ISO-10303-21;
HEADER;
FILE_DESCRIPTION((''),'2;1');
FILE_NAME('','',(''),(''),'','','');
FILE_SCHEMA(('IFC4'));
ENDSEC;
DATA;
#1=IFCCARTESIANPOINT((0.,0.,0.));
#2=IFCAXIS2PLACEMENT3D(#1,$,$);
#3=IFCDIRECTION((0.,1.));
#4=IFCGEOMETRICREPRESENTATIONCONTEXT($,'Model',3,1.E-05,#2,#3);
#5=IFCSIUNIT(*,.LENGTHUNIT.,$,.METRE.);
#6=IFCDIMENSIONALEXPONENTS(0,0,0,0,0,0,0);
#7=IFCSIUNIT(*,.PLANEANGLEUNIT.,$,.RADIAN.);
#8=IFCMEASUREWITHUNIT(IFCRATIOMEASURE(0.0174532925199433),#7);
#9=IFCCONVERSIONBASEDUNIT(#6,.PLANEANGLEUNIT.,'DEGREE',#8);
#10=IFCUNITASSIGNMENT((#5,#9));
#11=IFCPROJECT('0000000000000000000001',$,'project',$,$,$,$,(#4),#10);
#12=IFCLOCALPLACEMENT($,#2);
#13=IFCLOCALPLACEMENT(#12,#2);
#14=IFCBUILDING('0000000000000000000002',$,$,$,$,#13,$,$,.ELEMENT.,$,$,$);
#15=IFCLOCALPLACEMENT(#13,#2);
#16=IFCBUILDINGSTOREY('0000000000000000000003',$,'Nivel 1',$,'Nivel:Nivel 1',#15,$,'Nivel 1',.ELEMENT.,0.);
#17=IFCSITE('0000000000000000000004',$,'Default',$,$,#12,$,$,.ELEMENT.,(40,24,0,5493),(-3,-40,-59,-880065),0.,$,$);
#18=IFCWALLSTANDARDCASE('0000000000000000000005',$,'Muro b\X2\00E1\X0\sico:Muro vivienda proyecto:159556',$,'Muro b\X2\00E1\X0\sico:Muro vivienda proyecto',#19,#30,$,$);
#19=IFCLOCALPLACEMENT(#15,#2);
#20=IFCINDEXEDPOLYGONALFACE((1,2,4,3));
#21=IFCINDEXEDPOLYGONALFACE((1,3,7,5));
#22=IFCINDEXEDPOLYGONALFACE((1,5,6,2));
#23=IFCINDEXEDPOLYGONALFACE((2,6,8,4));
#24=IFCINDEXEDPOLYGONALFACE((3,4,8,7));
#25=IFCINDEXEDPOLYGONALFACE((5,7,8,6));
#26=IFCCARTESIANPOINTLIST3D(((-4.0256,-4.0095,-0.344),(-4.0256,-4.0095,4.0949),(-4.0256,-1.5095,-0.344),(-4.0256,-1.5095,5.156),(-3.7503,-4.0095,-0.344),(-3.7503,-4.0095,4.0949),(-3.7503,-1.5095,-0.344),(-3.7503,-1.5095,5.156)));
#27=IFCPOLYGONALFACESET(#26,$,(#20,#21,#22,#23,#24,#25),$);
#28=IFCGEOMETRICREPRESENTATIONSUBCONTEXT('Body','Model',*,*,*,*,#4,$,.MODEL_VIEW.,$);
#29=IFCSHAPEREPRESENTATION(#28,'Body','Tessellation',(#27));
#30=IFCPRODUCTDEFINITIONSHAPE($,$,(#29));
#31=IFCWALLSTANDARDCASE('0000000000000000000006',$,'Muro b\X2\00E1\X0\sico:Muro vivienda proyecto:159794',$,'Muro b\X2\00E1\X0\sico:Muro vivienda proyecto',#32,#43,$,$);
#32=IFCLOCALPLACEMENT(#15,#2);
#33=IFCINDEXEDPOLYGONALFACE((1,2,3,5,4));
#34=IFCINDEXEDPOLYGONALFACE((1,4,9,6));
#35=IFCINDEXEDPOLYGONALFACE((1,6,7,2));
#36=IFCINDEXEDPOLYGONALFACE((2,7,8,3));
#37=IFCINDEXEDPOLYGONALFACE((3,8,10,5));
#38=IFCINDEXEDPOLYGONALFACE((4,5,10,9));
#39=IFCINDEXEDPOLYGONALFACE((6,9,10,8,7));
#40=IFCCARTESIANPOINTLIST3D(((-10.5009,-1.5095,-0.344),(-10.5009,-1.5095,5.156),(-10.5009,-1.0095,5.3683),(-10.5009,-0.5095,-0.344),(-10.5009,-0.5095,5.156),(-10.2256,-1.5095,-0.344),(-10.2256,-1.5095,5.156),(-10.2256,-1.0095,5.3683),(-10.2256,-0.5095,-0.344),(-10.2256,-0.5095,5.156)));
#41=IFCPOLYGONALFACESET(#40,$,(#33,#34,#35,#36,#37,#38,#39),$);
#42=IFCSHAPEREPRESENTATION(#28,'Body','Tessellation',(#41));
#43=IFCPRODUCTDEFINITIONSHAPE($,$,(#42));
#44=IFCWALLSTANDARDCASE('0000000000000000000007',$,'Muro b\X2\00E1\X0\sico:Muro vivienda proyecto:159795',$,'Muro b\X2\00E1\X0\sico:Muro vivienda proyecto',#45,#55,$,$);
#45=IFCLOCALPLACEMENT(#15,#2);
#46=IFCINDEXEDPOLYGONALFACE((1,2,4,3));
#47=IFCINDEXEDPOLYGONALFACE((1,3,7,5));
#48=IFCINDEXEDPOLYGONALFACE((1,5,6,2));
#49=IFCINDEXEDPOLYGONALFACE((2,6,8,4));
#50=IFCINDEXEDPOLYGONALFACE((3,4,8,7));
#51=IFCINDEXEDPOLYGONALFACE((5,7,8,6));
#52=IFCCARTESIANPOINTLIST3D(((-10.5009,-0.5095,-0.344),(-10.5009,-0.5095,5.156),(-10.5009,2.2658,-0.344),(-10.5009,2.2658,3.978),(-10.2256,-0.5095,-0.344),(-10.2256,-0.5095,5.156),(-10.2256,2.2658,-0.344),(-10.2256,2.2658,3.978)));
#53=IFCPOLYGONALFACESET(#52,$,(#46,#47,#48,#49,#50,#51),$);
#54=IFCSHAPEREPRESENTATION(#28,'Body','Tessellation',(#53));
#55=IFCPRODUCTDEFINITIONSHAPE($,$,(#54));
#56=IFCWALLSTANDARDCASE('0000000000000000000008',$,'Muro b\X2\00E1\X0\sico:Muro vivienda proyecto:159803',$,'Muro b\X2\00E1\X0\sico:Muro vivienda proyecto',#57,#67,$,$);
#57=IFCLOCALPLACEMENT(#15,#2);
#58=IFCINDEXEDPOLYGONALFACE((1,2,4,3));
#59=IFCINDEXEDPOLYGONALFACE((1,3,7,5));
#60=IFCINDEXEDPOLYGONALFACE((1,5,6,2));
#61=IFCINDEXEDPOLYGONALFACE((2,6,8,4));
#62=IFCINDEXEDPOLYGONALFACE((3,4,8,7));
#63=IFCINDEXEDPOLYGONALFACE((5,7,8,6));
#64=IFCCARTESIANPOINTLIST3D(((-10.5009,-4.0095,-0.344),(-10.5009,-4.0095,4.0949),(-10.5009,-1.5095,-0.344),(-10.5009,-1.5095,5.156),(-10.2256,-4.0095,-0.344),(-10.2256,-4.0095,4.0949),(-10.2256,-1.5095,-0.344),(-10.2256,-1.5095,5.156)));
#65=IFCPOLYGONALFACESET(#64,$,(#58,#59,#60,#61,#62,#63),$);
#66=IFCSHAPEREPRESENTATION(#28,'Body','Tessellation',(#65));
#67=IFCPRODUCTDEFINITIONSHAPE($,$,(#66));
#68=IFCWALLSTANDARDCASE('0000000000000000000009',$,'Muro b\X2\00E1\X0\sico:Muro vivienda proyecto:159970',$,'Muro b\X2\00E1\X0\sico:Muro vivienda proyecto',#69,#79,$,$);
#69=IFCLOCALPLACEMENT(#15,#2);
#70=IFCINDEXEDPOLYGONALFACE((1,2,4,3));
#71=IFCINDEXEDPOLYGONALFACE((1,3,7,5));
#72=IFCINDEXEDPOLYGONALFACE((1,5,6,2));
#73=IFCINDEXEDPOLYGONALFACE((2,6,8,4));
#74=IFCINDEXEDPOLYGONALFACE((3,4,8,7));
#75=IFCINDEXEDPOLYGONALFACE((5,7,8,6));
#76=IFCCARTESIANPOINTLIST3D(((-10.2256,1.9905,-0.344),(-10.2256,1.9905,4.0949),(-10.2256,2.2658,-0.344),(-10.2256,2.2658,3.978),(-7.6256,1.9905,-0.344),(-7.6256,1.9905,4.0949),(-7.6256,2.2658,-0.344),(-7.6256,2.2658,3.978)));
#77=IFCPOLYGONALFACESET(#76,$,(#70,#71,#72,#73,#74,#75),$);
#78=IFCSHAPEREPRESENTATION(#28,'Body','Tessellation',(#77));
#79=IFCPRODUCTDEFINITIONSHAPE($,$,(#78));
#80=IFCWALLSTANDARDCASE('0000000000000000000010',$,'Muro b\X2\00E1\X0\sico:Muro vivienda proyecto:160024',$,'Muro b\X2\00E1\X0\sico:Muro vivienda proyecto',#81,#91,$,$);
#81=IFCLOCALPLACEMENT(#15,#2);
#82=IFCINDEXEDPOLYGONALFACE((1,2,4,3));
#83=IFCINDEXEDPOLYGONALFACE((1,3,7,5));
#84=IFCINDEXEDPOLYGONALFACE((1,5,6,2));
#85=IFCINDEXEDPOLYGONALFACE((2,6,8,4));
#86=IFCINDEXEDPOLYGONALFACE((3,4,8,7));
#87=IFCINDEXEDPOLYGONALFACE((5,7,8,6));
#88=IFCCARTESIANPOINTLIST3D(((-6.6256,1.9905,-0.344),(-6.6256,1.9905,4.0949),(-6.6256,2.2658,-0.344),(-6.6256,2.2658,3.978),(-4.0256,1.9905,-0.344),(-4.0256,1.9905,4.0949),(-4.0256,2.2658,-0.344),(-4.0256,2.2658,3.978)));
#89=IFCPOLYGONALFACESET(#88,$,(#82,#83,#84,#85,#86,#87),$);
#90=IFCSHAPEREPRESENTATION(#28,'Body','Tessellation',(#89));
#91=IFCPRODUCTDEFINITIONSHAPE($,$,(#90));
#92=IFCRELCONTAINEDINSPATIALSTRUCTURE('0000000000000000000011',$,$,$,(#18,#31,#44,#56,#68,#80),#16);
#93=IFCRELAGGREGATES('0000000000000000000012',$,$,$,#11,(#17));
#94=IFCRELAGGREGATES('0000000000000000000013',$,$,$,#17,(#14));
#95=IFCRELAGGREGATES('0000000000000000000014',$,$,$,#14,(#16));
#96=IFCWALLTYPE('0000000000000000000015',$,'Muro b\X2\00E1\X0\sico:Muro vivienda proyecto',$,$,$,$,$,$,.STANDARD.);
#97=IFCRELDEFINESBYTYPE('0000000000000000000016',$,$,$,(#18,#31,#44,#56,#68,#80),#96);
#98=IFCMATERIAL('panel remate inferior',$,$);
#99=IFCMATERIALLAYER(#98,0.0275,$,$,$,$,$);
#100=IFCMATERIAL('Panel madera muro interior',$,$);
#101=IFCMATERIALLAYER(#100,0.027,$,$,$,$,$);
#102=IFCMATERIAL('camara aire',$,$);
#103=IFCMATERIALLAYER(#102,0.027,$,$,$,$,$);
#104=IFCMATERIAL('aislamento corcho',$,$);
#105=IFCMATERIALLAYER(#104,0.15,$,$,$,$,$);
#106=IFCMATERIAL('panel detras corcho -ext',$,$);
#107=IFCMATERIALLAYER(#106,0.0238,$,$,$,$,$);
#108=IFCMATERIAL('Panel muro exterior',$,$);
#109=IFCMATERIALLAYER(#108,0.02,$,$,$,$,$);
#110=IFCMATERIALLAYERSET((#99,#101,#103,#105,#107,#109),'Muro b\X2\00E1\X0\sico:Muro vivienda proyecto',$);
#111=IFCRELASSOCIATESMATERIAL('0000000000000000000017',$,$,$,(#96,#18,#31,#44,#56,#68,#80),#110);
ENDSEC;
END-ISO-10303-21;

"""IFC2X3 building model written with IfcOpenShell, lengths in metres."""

from ifc_helpers import new_model, entity, si_unit, converted_unit, direction, frame, frame_2d, origin, place, context, subcontext, project, spatial, polyline, rectangle, extrude, clip, bounded_halfspace, material, layer, layer_set, layer_usage, type_object, element, save


model = new_model("IFC2X3")

# Units and contexts
model_context = context("Model", 3, precision=1e-05, world=origin(), true_north=direction((0.0, 1.0)))
body_context = subcontext(model_context, "Body", "Model", "MODEL_VIEW")
ifc_project = project(units=[si_unit("LENGTHUNIT", "METRE"), converted_unit("PLANEANGLEUNIT", "DEGREE", entity("IfcRatioMeasure", 0.0174532925199433), si_unit("PLANEANGLEUNIT", "RADIAN"), dimensions=[0, 0, 0, 0, 0, 0, 0])], contexts=[model_context])

# Site, building, storey
site_placement = place(None, origin())
site = spatial("IfcSite", under=ifc_project, at=site_placement, Name="Default", CompositionType="ELEMENT", RefLatitude=(40, 24, 0, 5493), RefLongitude=(-3, -40, -59, -880065), RefElevation=0.0)
building_placement = place(site_placement, origin())
building = spatial("IfcBuilding", under=site, at=building_placement, CompositionType="ELEMENT")
storey_placement = place(building_placement, origin())
storey = spatial("IfcBuildingStorey", under=building, at=storey_placement, Name="Nivel 1", ObjectType="Nivel:Nivel 1", LongName="Nivel 1", CompositionType="ELEMENT", Elevation=0.0)

# Shared definitions
ifc_material_1 = material(Name="aislamento corcho")
ifc_material_2 = material(Name="camara aire")
ifc_material_3 = material(Name="panel remate inferior")

# Walls
ifc_layer_1 = layer(ifc_material_3, 0.0275)
ifc_material_4 = material(Name="Panel madera muro interior")
ifc_layer_2 = layer(ifc_material_4, 0.027)
ifc_layer_3 = layer(ifc_material_2, 0.027)
ifc_layer_4 = layer(ifc_material_1, 0.15)
ifc_material_5 = material(Name="panel detras corcho -ext")
ifc_layer_5 = layer(ifc_material_5, 0.0238)
ifc_material_6 = material(Name="Panel muro exterior")
ifc_layer_6 = layer(ifc_material_6, 0.02)
ifc_layer_set_1 = layer_set([ifc_layer_1, ifc_layer_2, ifc_layer_3, ifc_layer_4, ifc_layer_5, ifc_layer_6], Name="Muro básico:Muro vivienda proyecto")
wall_type = type_object("IfcWallType", Name="Muro básico:Muro vivienda proyecto", PredefinedType="STANDARD", material=ifc_layer_set_1)
ifc_layer_usage_1 = layer_usage(ifc_layer_set_1, "AXIS2", "POSITIVE", -0.1376)
wall_1_placement = place(storey_placement, frame((-3.8879, -4.0095, -0.344), z_axis=(0.0, 0.0, 1.0), x_axis=(0.0, 1.0, 0.0)))
element("IfcWallStandardCase", 1, at=wall_1_placement, inside=storey, type_object=wall_type, material=ifc_layer_usage_1, Name="Muro básico:Muro vivienda proyecto:159556", ObjectType="Muro básico:Muro vivienda proyecto", context=body_context, shape_type="Clipping", body=[
    clip(extrude(rectangle(XDim=2.5, YDim=0.2753, at=frame_2d((1.25, 0.0), x_axis=(-1.0, 0.0))), origin(), (0.0, 0.0, 1.0), 5.5), bounded_halfspace(frame((0.0, -0.1376, 4.4389), z_axis=(-0.390731, 0.0, 0.920505), x_axis=(0.0, -1.0, 0.0)), False, frame((0.0, -0.1376, 4.4389)), polyline([(0.0, 0.0), (2.5, 0.0), (2.5, 0.2753), (0.0, 0.2753), (0.0, 0.0)]))),
])
ifc_layer_usage_2 = layer_usage(ifc_layer_set_1, "AXIS2", "POSITIVE", -0.1376)
wall_2_placement = place(storey_placement, frame((-10.3632, -0.5095, -0.344), z_axis=(0.0, 0.0, 1.0), x_axis=(0.0, -1.0, 0.0)))
element("IfcWallStandardCase", 2, at=wall_2_placement, inside=storey, type_object=wall_type, material=ifc_layer_usage_2, Name="Muro básico:Muro vivienda proyecto:159794", ObjectType="Muro básico:Muro vivienda proyecto", context=body_context, shape_type="Clipping", body=[
    clip(clip(extrude(rectangle(XDim=1.0, YDim=0.2753, at=frame_2d((0.5, 0.0), x_axis=(-1.0, 0.0))), origin(), (0.0, 0.0, 1.0), 5.7123), bounded_halfspace(frame((0.5, -0.1376, 5.7123), z_axis=(0.390731, 0.0, 0.920505), x_axis=(0.0, 1.0, 0.0)), False, frame((0.5, -0.1376, 5.7123)), polyline([(0.0, 0.0), (0.5, 0.0), (0.5, 0.2753), (0.0, 0.2753), (0.0, 0.0)]))), bounded_halfspace(frame((0.0, -0.1377, 5.5), z_axis=(-0.390731, 0.0, 0.920505), x_axis=(0.0, -1.0, 0.0)), False, frame((0.0, -0.1377, 5.5)), polyline([(0.0, 0.0), (0.5, 0.0), (0.5, 0.2753), (0.0, 0.2753), (0.0, 0.0)]))),
])
ifc_layer_usage_3 = layer_usage(ifc_layer_set_1, "AXIS2", "POSITIVE", -0.1376)
wall_3_placement = place(storey_placement, frame((-10.3632, 2.2658, -0.344), z_axis=(0.0, 0.0, 1.0), x_axis=(0.0, -1.0, 0.0)))
element("IfcWallStandardCase", 3, at=wall_3_placement, inside=storey, type_object=wall_type, material=ifc_layer_usage_3, Name="Muro básico:Muro vivienda proyecto:159795", ObjectType="Muro básico:Muro vivienda proyecto", context=body_context, shape_type="Clipping", body=[
    clip(extrude(rectangle(XDim=2.7753, YDim=0.2753, at=frame_2d((1.3877, 0.0), x_axis=(-1.0, 0.0))), origin(), (0.0, 0.0, 1.0), 5.5), bounded_halfspace(frame((0.0, -0.1377, 4.322), z_axis=(-0.390731, 0.0, 0.920505), x_axis=(0.0, -1.0, 0.0)), False, frame((0.0, -0.1377, 4.322)), polyline([(0.0, 0.0), (2.7753, 0.0), (2.7753, 0.2753), (0.2753, 0.2753), (0.0, 0.2753), (0.0, 0.0)]))),
])
ifc_layer_usage_4 = layer_usage(ifc_layer_set_1, "AXIS2", "NEGATIVE", 0.1376)
wall_4_placement = place(storey_placement, frame((-10.3632, -4.0095, -0.344), z_axis=(0.0, 0.0, 1.0), x_axis=(0.0, 1.0, 0.0)))
element("IfcWallStandardCase", 4, at=wall_4_placement, inside=storey, type_object=wall_type, material=ifc_layer_usage_4, Name="Muro básico:Muro vivienda proyecto:159803", ObjectType="Muro básico:Muro vivienda proyecto", context=body_context, shape_type="Clipping", body=[
    clip(extrude(rectangle(XDim=2.5, YDim=0.2753, at=frame_2d((1.25, 0.0), x_axis=(-1.0, 0.0))), origin(), (0.0, 0.0, 1.0), 5.5), bounded_halfspace(frame((0.0, -0.1377, 4.4389), z_axis=(-0.390731, 0.0, 0.920505), x_axis=(0.0, -1.0, 0.0)), False, frame((0.0, -0.1377, 4.4389)), polyline([(0.0, 0.0), (2.5, 0.0), (2.5, 0.2753), (0.0, 0.2753), (0.0, 0.0)]))),
])
ifc_layer_usage_5 = layer_usage(ifc_layer_set_1, "AXIS2", "NEGATIVE", 0.1376)
wall_5_placement = place(storey_placement, frame((-10.2256, 2.1282, -0.344)))
element("IfcWallStandardCase", 5, at=wall_5_placement, inside=storey, type_object=wall_type, material=ifc_layer_usage_5, Name="Muro básico:Muro vivienda proyecto:159970", ObjectType="Muro básico:Muro vivienda proyecto", context=body_context, shape_type="Clipping", body=[
    clip(extrude(rectangle(XDim=2.6, YDim=0.2753, at=frame_2d((1.3, 0.0), x_axis=(-1.0, 0.0))), origin(), (0.0, 0.0, 1.0), 4.4389), bounded_halfspace(frame((0.0, -0.1376, 4.4389), z_axis=(0.0, 0.390731, 0.920505), x_axis=(-1.0, 0.0, 0.0)), False, frame((0.0, -0.1376, 4.4389)), polyline([(0.0, 0.0), (2.6, 0.0), (2.6, 0.2753), (0.0, 0.2753), (0.0, 0.0)]))),
])
ifc_layer_usage_6 = layer_usage(ifc_layer_set_1, "AXIS2", "POSITIVE", -0.1376)
wall_6_placement = place(storey_placement, frame((-4.0256, 2.1282, -0.344), z_axis=(0.0, 0.0, 1.0), x_axis=(-1.0, 0.0, 0.0)))
element("IfcWallStandardCase", 6, at=wall_6_placement, inside=storey, type_object=wall_type, material=ifc_layer_usage_6, Name="Muro básico:Muro vivienda proyecto:160024", ObjectType="Muro básico:Muro vivienda proyecto", context=body_context, shape_type="Clipping", body=[
    clip(extrude(rectangle(XDim=2.6, YDim=0.2753, at=frame_2d((1.3, 0.0), x_axis=(-1.0, 0.0))), origin(), (0.0, 0.0, 1.0), 4.4389), bounded_halfspace(frame((0.0, -0.1376, 4.322), z_axis=(0.0, -0.390731, 0.920505), x_axis=(1.0, 0.0, 0.0)), False, frame((0.0, -0.1376, 4.322)), polyline([(0.0, 0.0), (2.6, 0.0), (2.6, 0.2753), (0.0, 0.2753), (0.0, 0.0)]))),
])

save(model, "model.ifc")
